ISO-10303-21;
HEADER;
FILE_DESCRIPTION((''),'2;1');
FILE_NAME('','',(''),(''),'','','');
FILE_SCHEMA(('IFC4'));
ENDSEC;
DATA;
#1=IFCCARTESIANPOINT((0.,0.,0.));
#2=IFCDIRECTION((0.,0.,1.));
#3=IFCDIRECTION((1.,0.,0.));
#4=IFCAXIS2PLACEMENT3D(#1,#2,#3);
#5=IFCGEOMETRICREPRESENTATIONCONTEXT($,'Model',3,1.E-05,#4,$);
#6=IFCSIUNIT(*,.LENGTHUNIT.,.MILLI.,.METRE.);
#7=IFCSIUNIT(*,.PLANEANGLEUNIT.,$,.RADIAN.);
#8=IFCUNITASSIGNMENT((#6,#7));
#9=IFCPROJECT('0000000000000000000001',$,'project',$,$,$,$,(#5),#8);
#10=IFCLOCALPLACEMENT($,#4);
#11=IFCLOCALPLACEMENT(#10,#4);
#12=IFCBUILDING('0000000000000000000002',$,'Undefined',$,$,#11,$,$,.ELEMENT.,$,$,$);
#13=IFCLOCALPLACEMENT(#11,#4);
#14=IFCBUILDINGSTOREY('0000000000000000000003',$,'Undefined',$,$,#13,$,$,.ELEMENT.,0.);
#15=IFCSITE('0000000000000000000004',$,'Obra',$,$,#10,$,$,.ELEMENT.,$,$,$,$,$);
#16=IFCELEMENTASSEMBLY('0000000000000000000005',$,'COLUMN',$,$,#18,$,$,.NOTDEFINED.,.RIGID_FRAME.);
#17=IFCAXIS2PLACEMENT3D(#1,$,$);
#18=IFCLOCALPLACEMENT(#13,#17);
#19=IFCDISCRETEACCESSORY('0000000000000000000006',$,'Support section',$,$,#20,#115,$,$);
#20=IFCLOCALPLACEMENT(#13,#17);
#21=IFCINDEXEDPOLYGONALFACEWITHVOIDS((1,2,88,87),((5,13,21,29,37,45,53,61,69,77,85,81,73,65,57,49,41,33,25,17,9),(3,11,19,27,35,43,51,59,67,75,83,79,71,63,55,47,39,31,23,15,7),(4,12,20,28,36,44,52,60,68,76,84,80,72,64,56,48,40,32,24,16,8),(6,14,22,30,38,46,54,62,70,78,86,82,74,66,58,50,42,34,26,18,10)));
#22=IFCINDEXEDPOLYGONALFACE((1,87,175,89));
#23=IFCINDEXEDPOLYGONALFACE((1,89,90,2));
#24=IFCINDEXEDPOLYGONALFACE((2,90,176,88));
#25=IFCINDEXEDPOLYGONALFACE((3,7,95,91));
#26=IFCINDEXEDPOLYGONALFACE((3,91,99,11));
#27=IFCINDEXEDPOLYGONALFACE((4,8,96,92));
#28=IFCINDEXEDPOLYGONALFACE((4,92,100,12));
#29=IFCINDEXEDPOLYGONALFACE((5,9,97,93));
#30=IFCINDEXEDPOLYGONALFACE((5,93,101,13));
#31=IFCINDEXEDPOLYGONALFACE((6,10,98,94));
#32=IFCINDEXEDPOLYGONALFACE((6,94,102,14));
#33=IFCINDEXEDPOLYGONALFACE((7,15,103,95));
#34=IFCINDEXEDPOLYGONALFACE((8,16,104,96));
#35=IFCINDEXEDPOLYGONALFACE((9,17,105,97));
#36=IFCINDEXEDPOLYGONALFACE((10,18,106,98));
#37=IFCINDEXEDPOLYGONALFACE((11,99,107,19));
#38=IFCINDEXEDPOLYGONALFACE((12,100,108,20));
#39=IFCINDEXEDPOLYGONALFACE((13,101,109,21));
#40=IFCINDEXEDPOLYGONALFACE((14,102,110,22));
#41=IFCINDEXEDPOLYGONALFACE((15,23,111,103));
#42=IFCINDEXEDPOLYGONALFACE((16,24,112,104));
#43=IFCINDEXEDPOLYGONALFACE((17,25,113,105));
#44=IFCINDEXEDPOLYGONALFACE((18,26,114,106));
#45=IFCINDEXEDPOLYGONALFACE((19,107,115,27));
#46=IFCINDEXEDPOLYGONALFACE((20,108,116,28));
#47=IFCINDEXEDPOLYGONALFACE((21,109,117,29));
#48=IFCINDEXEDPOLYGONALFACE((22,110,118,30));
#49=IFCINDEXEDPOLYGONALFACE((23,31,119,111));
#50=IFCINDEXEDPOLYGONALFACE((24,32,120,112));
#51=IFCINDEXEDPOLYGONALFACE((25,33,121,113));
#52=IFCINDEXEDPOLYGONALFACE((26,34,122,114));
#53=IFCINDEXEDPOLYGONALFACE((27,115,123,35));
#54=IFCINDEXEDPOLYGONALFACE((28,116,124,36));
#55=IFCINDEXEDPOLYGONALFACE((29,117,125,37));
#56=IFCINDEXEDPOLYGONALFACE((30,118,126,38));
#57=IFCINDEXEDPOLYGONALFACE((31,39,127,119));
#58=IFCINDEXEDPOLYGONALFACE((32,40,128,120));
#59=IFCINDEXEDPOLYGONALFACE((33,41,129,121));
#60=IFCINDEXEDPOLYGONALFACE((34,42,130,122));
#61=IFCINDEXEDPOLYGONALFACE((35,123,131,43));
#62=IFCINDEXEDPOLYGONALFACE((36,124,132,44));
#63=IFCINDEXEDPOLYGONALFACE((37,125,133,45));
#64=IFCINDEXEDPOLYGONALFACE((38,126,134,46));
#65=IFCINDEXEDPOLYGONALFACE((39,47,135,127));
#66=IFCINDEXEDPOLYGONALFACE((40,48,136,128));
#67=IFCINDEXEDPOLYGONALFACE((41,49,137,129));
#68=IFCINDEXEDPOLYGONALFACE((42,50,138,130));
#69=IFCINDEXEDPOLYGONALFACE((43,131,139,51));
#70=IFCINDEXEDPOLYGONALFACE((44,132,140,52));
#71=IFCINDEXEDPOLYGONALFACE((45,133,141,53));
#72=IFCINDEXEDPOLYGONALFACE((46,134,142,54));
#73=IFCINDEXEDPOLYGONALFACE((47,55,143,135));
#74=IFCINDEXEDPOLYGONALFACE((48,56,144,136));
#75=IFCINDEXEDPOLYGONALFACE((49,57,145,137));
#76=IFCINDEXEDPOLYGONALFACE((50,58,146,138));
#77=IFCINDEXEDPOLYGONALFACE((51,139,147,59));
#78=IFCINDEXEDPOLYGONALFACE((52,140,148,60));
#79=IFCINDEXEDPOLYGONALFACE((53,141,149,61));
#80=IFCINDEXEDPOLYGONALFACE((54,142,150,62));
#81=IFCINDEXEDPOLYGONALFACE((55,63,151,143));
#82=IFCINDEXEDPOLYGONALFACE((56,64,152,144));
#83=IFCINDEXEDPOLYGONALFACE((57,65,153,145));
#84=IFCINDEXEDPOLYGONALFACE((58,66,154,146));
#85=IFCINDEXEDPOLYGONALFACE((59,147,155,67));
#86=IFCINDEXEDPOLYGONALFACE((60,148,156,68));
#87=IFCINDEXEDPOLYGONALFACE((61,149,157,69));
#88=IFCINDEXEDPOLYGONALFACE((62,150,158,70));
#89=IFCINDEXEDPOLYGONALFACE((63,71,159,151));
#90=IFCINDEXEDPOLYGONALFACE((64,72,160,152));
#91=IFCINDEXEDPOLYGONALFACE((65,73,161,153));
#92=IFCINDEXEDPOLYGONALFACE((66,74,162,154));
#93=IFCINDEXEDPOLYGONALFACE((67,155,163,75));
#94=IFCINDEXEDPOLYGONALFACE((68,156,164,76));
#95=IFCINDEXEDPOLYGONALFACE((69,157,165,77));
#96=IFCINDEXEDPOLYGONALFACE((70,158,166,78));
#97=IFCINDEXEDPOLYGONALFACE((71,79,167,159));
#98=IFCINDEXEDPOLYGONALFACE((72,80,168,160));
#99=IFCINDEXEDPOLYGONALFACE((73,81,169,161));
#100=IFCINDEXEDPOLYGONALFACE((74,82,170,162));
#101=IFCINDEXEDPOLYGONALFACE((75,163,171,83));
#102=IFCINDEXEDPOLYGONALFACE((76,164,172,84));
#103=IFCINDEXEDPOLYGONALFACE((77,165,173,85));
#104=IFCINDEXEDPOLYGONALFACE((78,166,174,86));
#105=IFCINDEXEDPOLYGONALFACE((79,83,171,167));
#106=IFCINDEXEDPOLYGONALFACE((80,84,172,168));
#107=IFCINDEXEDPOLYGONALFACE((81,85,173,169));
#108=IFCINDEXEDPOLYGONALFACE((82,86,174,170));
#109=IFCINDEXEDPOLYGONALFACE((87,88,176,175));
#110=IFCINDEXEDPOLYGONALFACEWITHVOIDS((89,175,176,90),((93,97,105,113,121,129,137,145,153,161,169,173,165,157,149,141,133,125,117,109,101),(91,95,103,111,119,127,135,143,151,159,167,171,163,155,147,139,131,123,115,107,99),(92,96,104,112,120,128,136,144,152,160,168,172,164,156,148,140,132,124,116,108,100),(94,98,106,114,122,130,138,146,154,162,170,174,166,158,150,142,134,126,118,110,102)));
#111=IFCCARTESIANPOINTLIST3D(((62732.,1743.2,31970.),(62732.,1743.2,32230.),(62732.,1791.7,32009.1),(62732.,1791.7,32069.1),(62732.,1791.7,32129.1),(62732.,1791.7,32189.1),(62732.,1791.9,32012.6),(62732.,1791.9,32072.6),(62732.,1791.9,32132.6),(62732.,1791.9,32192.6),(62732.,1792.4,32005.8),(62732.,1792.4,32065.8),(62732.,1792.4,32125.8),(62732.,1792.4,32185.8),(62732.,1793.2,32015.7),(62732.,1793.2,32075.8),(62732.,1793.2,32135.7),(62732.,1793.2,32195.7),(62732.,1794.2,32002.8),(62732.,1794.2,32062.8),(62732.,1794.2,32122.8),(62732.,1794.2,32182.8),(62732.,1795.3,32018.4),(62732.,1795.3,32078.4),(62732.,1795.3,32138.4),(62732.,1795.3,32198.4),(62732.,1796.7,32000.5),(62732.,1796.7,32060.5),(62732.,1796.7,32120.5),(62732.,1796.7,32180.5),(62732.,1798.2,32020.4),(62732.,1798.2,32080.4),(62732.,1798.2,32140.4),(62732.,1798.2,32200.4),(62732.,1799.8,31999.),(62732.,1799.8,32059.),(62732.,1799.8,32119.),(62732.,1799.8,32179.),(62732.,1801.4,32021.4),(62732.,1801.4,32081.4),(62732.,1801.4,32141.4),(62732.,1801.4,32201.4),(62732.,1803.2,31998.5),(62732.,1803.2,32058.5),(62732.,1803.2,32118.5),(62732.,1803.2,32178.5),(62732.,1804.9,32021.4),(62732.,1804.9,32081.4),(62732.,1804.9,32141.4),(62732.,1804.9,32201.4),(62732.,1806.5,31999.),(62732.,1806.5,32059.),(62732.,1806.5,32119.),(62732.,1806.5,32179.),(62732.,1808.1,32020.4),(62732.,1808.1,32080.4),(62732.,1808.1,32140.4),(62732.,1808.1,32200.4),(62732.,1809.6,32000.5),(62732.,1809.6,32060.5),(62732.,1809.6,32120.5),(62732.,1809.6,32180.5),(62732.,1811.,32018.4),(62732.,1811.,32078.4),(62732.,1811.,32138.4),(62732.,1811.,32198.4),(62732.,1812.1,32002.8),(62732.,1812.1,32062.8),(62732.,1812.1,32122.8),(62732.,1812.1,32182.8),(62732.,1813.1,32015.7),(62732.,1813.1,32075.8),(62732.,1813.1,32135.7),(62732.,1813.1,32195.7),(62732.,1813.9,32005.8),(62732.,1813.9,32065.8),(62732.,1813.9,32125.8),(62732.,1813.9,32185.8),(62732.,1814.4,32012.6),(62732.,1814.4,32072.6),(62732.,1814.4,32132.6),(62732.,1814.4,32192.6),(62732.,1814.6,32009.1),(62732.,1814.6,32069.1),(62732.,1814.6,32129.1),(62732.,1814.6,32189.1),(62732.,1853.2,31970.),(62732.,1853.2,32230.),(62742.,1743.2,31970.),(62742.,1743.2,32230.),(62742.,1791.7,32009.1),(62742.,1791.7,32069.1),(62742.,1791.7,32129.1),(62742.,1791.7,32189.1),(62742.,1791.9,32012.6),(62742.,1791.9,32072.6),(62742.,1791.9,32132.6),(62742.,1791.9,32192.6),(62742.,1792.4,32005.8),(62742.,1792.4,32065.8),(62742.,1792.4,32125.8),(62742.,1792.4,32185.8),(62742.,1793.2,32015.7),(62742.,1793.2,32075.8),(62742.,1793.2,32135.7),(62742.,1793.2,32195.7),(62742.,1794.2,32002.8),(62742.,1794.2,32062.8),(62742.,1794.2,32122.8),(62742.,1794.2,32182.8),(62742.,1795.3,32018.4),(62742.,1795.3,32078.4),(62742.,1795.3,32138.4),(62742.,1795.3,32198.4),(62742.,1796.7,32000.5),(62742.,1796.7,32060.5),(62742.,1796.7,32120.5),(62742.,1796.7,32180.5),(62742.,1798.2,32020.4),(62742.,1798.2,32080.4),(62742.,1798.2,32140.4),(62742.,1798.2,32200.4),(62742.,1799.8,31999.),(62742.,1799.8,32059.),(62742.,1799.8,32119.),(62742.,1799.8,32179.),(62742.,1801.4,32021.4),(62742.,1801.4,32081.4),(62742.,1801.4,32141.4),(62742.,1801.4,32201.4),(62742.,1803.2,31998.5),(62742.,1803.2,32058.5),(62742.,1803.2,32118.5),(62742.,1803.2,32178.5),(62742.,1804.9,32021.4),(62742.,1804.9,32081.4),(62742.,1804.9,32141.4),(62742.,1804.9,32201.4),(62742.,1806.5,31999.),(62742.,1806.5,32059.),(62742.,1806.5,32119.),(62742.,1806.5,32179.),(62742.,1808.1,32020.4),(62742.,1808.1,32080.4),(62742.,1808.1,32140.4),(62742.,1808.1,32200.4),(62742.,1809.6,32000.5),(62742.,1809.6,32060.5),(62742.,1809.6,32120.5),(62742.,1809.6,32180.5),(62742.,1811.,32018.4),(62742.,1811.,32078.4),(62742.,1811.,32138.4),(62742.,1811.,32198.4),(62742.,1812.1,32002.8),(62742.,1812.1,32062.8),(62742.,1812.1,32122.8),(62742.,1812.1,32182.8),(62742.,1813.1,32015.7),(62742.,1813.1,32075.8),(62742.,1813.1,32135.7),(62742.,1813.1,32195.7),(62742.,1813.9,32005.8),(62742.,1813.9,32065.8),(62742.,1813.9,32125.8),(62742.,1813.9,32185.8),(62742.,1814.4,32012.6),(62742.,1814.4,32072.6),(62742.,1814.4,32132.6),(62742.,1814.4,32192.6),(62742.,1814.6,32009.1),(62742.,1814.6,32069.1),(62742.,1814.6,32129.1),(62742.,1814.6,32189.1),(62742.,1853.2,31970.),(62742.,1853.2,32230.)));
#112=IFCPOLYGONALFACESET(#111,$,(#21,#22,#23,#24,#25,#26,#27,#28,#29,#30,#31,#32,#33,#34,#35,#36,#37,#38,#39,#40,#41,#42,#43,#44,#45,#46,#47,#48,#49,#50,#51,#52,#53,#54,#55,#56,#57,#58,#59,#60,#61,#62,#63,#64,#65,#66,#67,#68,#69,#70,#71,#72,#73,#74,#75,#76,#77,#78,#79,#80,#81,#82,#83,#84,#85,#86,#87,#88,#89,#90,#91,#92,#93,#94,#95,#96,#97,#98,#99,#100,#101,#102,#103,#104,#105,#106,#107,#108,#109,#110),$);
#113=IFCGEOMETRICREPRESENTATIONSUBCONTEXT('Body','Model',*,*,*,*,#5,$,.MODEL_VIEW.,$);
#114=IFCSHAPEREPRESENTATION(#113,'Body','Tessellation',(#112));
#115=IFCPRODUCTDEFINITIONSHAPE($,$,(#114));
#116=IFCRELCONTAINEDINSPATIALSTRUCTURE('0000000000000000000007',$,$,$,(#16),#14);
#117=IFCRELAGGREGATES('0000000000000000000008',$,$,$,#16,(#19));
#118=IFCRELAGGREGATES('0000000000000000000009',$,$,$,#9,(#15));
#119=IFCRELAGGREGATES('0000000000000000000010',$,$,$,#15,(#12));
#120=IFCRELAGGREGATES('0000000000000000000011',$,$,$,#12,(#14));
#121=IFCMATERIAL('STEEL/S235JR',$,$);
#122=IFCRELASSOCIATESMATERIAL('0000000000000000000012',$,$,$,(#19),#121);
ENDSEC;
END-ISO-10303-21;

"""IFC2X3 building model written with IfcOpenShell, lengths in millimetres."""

from ifc_helpers import new_model, si_unit, frame, origin_with_axes, origin_2d_with_axis, place, context, subcontext, project, spatial, rectangle, circle, extrude, source, transform, mapped, material, element, aggregate, save


model = new_model("IFC2X3")

# Units and contexts
model_context = context("Model", 3, precision=1e-05, world=origin_with_axes())
body_context = subcontext(model_context, "Body", "Model", "MODEL_VIEW")
ifc_project = project(units=[si_unit("LENGTHUNIT", "METRE", prefix="MILLI"), si_unit("PLANEANGLEUNIT", "RADIAN")], contexts=[model_context])

# Site, building, storey
site_placement = place(None, origin_with_axes())
site = spatial("IfcSite", under=ifc_project, at=site_placement, Name="Obra", CompositionType="ELEMENT")
building_placement = place(site_placement, origin_with_axes())
building = spatial("IfcBuilding", under=site, at=building_placement, Name="Undefined", CompositionType="ELEMENT")
storey_placement = place(building_placement, origin_with_axes())
storey = spatial("IfcBuildingStorey", under=building, at=storey_placement, Name="Undefined", CompositionType="ELEMENT", Elevation=0.0)

# Shared definitions
ifc_material_1 = material(Name="STEEL/S235JR")

# Element assembly, discrete accessory, opening
assembly_1_placement = place(storey_placement, origin_with_axes())
assembly_1 = element("IfcElementAssembly", 1, at=assembly_1_placement, inside=storey, Name="COLUMN", AssemblyPlace="NOTDEFINED", PredefinedType="RIGID_FRAME")
discrete_accessory_1_placement = place(assembly_1_placement, frame((62737.0, 1798.2, 31970.0), z_axis=(0.0, 0.0, 1.0), x_axis=(0.0, -1.0, 0.0)))
discrete_accessory_1 = element("IfcDiscreteAccessory", 2, at=discrete_accessory_1_placement, material=ifc_material_1, Name="Support section", context=body_context, shape_type="SweptSolid", body=[
    extrude(rectangle(XDim=10.0, YDim=110.0, at=origin_2d_with_axis()), frame((0.0, 0.0, 260.0), z_axis=(0.0, 0.0, -1.0), x_axis=(0.0, 1.0, 0.0)), (0.0, 0.0, 1.0), 260.0),
])
shared_shape_1 = source(origin_with_axes(), body_context, "Body", "SweptSolid", [
    extrude(circle(Radius=11.5, at=origin_2d_with_axis()), frame((0.0, -14.4, 0.0), z_axis=(0.0, 1.0, 0.0), x_axis=(1.0, 0.0, 0.0)), (0.0, 0.0, 1.0), 10.2),
])
opening_1_placement = place(assembly_1_placement, frame((62727.7, 1753.2, 32300.0), z_axis=(0.0, 1.0, 0.0), x_axis=(0.0, 0.0, -1.0)))
element("IfcOpeningElement", 3, at=opening_1_placement, cuts=discrete_accessory_1, ObjectType="Opening", context=body_context, shape_type="MappedRepresentation", body=[
    mapped(shared_shape_1, transform((110.0, 0.0, 50.0))),
    mapped(shared_shape_1, transform((170.0, 0.0, 50.0))),
    mapped(shared_shape_1, transform((230.0, 0.0, 50.0))),
    mapped(shared_shape_1, transform((290.0, 0.0, 50.0))),
])

aggregate(assembly_1, [discrete_accessory_1])

save(model, "model.ifc")
